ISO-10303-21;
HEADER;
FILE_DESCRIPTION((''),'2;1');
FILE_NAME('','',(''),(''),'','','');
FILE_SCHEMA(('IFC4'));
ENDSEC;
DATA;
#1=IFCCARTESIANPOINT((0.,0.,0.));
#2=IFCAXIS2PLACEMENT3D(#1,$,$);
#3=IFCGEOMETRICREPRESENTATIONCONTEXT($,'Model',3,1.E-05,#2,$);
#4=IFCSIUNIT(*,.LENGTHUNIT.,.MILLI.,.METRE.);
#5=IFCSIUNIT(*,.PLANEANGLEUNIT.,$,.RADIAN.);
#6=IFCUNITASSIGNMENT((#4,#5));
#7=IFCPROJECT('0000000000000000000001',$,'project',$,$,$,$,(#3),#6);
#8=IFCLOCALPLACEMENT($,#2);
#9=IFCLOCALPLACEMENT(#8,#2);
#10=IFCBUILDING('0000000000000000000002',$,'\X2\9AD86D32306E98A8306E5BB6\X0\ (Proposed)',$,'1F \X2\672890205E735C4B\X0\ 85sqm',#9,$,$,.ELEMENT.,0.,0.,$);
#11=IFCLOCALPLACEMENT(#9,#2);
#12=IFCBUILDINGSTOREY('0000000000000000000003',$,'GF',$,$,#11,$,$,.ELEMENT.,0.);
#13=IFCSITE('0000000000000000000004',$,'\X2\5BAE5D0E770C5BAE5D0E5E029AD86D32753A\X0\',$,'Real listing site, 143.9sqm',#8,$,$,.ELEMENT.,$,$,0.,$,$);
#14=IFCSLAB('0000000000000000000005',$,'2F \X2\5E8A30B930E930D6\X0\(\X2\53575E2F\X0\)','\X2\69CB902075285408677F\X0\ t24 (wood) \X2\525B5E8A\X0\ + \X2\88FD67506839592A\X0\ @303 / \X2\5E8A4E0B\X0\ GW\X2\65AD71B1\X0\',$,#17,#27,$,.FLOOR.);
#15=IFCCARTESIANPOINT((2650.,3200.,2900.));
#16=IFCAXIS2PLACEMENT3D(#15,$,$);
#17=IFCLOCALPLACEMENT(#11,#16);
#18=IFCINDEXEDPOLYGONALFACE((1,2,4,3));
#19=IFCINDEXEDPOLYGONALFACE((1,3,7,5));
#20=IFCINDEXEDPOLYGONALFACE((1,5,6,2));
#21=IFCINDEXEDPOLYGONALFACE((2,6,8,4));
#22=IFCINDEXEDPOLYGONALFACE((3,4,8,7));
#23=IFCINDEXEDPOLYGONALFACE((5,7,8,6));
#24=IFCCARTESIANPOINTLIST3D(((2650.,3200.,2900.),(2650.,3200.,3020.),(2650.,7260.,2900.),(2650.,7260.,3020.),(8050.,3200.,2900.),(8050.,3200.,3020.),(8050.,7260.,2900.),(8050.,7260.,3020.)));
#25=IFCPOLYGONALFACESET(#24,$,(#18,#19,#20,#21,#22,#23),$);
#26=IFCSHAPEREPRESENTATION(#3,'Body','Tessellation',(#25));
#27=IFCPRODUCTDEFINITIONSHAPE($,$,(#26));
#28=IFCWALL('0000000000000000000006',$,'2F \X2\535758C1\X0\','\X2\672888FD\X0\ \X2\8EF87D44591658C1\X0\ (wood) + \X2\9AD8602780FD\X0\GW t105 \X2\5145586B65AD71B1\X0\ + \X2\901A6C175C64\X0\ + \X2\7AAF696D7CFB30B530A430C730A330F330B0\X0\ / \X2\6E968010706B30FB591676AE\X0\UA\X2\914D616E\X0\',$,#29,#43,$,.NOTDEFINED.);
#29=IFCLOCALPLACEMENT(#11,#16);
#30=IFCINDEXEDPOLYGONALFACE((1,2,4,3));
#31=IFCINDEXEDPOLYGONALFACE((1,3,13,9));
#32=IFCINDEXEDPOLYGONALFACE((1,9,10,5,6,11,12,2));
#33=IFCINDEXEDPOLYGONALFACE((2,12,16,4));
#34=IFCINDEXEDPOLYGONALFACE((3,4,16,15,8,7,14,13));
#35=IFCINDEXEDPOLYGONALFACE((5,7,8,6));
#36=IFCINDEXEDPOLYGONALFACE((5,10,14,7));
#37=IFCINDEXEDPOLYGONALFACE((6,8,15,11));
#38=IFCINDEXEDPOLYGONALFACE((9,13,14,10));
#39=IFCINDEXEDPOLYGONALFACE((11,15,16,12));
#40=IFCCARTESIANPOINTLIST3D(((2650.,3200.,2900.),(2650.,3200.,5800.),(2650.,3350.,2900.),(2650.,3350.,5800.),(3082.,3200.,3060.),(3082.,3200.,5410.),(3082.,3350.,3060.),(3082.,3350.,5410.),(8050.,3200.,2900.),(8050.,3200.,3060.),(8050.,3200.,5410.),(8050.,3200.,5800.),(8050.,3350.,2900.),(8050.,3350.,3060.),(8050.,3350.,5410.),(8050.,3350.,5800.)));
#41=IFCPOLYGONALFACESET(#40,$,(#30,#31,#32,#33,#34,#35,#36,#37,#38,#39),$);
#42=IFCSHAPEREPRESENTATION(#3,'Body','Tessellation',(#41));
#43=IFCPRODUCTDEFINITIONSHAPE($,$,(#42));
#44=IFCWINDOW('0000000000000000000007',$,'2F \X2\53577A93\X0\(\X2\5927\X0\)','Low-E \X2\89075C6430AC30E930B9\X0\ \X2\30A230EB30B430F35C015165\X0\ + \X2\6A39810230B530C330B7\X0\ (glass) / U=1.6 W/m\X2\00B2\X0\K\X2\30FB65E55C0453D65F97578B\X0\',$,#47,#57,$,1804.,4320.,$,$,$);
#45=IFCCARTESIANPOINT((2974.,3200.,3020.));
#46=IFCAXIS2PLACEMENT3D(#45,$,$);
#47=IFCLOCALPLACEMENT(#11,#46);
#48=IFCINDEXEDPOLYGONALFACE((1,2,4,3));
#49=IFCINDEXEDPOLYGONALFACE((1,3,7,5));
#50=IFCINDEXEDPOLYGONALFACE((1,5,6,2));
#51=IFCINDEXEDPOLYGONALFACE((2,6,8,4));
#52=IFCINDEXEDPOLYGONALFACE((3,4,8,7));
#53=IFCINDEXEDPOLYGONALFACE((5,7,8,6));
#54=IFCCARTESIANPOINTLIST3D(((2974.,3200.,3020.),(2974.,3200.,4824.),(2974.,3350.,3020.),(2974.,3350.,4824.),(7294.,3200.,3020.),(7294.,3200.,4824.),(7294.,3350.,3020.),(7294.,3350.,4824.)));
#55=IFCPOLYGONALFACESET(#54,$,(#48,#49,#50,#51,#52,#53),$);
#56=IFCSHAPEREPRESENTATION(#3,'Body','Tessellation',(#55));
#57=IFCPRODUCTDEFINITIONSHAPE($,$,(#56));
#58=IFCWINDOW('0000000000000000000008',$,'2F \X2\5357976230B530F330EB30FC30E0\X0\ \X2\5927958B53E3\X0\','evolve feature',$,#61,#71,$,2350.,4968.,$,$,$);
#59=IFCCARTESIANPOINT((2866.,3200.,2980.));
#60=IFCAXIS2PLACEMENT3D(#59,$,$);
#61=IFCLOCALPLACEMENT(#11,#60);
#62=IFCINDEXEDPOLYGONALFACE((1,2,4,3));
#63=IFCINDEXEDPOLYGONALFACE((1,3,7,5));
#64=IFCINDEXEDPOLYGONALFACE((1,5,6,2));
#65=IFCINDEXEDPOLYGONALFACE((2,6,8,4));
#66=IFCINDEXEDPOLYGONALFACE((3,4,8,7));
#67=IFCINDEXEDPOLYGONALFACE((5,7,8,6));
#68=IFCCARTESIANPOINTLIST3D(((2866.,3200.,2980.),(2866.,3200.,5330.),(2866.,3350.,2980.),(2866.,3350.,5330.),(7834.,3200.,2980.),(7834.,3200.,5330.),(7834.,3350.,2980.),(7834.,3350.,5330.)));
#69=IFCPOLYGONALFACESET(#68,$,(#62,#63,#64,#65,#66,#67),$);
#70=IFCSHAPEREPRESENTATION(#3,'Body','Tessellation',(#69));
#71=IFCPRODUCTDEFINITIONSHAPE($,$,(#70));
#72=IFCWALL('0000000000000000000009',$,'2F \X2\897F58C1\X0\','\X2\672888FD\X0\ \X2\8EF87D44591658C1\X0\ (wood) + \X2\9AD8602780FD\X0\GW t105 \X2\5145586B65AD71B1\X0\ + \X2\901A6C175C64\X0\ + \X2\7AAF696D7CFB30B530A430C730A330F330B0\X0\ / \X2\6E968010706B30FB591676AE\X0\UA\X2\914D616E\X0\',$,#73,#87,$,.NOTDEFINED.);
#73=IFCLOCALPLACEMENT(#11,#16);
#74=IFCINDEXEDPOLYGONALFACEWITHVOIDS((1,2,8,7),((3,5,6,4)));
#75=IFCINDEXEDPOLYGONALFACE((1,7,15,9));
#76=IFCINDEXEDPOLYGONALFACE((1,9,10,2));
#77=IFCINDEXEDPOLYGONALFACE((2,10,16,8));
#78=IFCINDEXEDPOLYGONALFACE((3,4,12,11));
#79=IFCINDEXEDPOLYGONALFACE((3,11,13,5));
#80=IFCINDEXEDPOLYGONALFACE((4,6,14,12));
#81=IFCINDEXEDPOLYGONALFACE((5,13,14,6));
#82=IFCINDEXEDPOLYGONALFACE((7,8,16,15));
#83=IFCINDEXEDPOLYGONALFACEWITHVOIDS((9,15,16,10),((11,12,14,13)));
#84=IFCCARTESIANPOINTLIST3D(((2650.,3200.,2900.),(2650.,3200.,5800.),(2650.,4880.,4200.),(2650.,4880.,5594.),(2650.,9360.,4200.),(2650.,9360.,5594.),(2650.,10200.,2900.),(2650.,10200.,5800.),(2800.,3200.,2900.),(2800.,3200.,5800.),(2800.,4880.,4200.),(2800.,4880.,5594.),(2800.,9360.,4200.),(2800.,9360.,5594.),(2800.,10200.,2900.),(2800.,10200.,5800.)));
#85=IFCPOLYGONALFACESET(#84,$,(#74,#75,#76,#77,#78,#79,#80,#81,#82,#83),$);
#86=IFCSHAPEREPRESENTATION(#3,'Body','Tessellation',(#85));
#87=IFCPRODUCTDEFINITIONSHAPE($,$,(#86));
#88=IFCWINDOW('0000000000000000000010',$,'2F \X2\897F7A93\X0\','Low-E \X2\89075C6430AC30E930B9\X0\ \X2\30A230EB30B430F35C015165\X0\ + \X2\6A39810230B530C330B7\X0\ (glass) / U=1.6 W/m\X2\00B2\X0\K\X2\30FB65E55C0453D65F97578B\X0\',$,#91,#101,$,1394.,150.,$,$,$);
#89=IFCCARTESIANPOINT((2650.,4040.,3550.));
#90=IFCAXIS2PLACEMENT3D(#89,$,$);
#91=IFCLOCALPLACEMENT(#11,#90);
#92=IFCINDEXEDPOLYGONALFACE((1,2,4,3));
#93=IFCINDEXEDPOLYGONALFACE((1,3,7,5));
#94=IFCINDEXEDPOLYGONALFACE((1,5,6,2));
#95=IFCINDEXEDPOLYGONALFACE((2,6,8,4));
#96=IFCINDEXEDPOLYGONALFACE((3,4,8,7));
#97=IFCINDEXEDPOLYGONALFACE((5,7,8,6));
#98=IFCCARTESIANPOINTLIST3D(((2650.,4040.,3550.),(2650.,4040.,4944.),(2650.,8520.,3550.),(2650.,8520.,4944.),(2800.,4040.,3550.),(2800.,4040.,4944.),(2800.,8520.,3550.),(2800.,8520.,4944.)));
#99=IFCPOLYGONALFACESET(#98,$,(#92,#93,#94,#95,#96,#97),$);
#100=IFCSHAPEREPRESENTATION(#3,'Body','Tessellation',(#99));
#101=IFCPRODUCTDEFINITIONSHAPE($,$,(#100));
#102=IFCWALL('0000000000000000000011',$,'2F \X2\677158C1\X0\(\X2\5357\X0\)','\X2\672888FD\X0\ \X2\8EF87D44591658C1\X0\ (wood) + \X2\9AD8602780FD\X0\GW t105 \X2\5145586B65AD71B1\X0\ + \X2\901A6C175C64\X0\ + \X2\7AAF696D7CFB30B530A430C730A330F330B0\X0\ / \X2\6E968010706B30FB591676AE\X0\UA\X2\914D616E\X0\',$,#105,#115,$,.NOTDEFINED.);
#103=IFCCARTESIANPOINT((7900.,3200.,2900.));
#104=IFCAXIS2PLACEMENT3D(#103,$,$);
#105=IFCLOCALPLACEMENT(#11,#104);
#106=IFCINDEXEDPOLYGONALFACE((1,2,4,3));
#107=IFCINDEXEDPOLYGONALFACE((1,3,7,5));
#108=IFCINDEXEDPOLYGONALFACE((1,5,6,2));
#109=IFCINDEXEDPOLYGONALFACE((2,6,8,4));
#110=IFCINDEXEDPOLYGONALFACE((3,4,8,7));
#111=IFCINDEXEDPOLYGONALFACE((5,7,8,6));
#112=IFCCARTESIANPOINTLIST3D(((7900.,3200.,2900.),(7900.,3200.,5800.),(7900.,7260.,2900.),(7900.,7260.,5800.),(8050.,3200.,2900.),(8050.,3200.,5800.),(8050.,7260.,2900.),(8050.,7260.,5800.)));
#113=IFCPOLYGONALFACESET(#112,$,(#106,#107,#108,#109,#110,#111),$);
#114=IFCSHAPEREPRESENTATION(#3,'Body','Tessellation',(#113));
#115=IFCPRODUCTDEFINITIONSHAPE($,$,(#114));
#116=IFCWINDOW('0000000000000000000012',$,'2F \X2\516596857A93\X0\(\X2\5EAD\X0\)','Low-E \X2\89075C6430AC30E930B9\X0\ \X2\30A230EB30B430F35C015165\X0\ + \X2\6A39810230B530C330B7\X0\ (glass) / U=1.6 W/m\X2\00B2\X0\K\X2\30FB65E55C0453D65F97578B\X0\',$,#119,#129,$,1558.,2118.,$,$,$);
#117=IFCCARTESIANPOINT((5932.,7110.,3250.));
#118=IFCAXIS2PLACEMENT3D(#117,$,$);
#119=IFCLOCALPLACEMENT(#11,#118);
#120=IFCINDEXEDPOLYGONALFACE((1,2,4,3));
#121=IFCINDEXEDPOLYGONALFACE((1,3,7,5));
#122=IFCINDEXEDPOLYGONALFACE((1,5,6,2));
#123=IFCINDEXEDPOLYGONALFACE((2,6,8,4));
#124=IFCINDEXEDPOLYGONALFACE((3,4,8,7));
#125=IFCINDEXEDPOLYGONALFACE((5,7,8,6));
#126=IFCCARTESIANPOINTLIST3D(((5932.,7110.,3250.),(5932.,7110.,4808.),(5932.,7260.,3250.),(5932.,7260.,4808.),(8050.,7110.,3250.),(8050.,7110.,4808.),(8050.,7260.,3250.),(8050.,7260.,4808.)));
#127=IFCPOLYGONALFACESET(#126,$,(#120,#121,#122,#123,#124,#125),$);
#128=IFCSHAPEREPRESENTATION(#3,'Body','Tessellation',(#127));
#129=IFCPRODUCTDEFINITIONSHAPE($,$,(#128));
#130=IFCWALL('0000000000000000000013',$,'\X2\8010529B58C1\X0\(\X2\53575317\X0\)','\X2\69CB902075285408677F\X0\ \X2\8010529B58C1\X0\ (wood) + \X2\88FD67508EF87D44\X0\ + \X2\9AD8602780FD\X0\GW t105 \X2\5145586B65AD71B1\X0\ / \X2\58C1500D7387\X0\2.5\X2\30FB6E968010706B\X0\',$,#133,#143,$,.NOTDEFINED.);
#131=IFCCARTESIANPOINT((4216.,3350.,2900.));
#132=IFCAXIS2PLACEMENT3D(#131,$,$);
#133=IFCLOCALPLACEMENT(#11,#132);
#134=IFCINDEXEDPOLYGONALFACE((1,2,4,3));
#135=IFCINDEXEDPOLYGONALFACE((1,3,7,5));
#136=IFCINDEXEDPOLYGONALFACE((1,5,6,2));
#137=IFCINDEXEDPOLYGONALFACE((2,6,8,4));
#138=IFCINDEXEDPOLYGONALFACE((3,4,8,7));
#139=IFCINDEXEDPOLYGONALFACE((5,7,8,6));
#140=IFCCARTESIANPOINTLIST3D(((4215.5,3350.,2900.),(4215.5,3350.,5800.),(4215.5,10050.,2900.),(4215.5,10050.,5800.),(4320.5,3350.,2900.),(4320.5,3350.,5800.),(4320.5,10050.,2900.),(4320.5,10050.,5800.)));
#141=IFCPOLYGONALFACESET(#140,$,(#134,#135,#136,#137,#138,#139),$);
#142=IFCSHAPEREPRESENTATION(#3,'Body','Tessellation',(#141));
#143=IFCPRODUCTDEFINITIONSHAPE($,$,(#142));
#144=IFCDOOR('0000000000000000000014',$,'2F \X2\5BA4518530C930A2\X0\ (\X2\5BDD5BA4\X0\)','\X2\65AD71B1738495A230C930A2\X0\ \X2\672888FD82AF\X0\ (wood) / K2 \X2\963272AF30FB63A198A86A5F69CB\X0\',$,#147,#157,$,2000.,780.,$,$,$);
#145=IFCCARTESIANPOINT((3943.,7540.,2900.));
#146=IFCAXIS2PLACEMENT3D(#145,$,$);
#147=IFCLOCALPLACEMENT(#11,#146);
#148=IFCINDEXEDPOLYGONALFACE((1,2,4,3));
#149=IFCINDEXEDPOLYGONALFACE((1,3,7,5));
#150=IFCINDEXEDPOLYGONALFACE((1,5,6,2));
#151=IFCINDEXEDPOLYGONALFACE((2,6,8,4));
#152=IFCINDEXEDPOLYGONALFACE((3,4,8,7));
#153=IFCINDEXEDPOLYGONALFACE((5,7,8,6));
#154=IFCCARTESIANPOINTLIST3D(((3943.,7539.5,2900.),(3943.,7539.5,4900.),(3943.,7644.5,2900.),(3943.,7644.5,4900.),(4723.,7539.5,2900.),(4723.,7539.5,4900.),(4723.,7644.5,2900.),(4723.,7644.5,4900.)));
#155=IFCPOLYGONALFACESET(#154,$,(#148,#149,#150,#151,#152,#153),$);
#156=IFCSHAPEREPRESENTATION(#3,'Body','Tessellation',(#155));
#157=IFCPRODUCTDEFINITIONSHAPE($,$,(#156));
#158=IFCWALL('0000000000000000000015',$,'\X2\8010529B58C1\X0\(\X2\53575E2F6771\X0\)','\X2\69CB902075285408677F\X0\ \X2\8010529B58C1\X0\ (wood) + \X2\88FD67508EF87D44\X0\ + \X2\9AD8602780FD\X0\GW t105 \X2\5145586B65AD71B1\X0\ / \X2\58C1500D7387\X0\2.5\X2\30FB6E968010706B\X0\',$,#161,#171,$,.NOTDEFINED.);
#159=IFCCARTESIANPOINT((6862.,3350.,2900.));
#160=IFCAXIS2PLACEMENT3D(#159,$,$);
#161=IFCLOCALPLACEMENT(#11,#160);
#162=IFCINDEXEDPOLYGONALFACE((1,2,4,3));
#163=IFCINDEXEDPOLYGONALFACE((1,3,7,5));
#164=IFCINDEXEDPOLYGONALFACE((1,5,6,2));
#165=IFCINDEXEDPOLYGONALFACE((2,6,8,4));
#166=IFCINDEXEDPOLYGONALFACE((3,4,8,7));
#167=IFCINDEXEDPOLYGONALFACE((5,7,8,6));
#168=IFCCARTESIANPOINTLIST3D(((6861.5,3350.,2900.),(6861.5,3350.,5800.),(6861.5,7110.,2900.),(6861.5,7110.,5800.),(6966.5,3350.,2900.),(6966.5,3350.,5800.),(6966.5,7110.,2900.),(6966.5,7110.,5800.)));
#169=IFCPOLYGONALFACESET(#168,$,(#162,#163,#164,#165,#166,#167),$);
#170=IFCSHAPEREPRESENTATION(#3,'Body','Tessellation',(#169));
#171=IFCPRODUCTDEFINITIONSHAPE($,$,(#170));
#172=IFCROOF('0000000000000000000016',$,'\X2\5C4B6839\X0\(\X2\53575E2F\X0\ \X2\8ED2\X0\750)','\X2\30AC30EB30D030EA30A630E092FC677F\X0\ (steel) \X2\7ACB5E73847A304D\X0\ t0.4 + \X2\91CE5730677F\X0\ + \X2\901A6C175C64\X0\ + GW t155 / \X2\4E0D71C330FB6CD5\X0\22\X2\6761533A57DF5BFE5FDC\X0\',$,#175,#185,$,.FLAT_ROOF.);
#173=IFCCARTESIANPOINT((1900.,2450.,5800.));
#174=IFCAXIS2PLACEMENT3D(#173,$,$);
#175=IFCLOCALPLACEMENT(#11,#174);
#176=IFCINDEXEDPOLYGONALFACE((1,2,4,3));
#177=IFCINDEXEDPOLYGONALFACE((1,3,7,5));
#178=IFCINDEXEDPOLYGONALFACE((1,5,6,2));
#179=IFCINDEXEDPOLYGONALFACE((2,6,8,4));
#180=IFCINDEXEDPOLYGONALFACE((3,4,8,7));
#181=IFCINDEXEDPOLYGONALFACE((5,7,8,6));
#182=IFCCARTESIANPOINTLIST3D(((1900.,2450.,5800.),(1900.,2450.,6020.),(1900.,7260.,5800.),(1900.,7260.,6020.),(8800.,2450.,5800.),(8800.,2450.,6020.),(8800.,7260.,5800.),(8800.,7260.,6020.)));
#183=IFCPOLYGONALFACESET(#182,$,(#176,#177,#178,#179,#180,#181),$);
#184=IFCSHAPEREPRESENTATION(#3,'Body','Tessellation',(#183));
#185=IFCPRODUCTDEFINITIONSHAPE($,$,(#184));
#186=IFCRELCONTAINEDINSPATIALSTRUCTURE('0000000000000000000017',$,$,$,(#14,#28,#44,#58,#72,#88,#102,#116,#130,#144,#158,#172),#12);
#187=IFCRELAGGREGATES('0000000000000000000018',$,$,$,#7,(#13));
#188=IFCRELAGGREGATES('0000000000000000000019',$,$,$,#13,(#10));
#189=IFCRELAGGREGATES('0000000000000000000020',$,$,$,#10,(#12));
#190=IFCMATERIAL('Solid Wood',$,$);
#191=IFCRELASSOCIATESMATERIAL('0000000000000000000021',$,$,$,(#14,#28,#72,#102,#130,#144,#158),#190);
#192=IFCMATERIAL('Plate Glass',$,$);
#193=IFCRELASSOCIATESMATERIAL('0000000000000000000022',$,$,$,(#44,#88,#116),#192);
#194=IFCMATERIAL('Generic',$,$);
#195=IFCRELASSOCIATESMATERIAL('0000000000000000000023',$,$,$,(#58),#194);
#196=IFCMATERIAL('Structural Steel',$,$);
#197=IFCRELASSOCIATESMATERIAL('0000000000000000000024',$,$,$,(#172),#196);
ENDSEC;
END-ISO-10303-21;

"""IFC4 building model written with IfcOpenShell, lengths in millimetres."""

from ifc_helpers import new_model, si_unit, frame, frame_2d, origin, place, context, project, spatial, rectangle, extrude, material, element, fill, save


model = new_model("IFC4")

# Units and contexts
model_context = context("Model", 3, precision=1e-05, world=origin())
ifc_project = project(units=[si_unit("LENGTHUNIT", "METRE", prefix="MILLI"), si_unit("PLANEANGLEUNIT", "RADIAN")], contexts=[model_context])

# Site, building, storey
site_placement = place(None, origin())
site = spatial("IfcSite", under=ifc_project, at=site_placement, Name="宮崎県宮崎市高洲町", ObjectType="Real listing site, 143.9sqm", CompositionType="ELEMENT", RefElevation=0.0)
building_placement = place(site_placement, origin())
building = spatial("IfcBuilding", under=site, at=building_placement, Name="高洲の風の家 (Proposed)", ObjectType="1F 木造平屋 85sqm", CompositionType="ELEMENT", ElevationOfRefHeight=0.0, ElevationOfTerrain=0.0)
storey_placement = place(building_placement, origin())
storey = spatial("IfcBuildingStorey", under=building, at=storey_placement, Name="GF", CompositionType="ELEMENT", Elevation=0.0)

# Slab
ifc_material_1 = material(Name="Solid Wood")
slab_placement = place(storey_placement, frame((2650.0, 3200.0, 2900.0)))
element("IfcSlab", 1, at=slab_placement, inside=storey, material=ifc_material_1, Name="2F 床スラブ(南帯)", Description="構造用合板 t24 (wood) 剛床 + 製材根太 @303 / 床下 GW断熱", PredefinedType="FLOOR", context=model_context, shape_type="SweptSolid", body=[
    extrude(rectangle(XDim=5400.0, YDim=4060.0, at=frame_2d((2700.0, 2030.0))), frame((2650.0, 3200.0, 2900.0)), (0.0, 0.0, 1.0), 120.0),
])

# Wall, openings, windows
wall_1_placement = place(storey_placement, frame((2650.0, 3200.0, 2900.0)))
wall_1 = element("IfcWall", 2, at=wall_1_placement, inside=storey, material=ifc_material_1, Name="2F 南壁", Description="木製 軸組外壁 (wood) + 高性能GW t105 充填断熱 + 通気層 + 窯業系サイディング / 準耐火・外皮UA配慮", PredefinedType="NOTDEFINED", context=model_context, shape_type="SweptSolid", body=[
    extrude(rectangle(XDim=5400.0, YDim=150.0, at=frame_2d((2700.0, 75.0))), frame((2650.0, 3200.0, 2900.0)), (0.0, 0.0, 1.0), 2900.0),
])
opening_1_placement = place(storey_placement, frame((2974.0, 3200.0, 3020.0)))
opening_1 = element("IfcOpeningElement", 3, at=opening_1_placement, cuts=wall_1, PredefinedType="NOTDEFINED", context=model_context, shape_type="SweptSolid", body=[
    extrude(rectangle(XDim=4320.0, YDim=150.0, at=frame_2d((2160.0, 75.0))), frame((2974.0, 3200.0, 3020.0)), (0.0, 0.0, 1.0), 1804.0),
])
opening_2_placement = place(storey_placement, frame((2866.0, 3200.0, 2980.0)))
opening_2 = element("IfcOpeningElement", 4, at=opening_2_placement, cuts=wall_1, PredefinedType="NOTDEFINED", context=model_context, shape_type="SweptSolid", body=[
    extrude(rectangle(XDim=4968.0, YDim=150.0, at=frame_2d((2484.0, 75.0))), frame((2866.0, 3200.0, 2980.0)), (0.0, 0.0, 1.0), 2350.0),
])
ifc_material_2 = material(Name="Plate Glass")
window_1_placement = place(storey_placement, frame((2974.0, 3200.0, 3020.0)))
window_1 = element("IfcWindow", 5, at=window_1_placement, inside=storey, material=ifc_material_2, Name="2F 南窓(大)", Description="Low-E 複層ガラス アルゴン封入 + 樹脂サッシ (glass) / U=1.6 W/m²K・日射取得型", OverallHeight=1804.0, OverallWidth=4320.0, context=model_context, shape_type="SweptSolid", body=[
    extrude(rectangle(XDim=4320.0, YDim=150.0, at=frame_2d((2160.0, 75.0))), frame((2974.0, 3200.0, 3020.0)), (0.0, 0.0, 1.0), 1804.0),
])
fill(opening_1, window_1)
ifc_material_3 = material(Name="Generic")
window_2_placement = place(storey_placement, frame((2866.0, 3200.0, 2980.0)))
window_2 = element("IfcWindow", 6, at=window_2_placement, inside=storey, material=ifc_material_3, Name="2F 南面サンルーム 大開口", Description="evolve feature", OverallHeight=2350.0, OverallWidth=4968.0, context=model_context, shape_type="SweptSolid", body=[
    extrude(rectangle(XDim=4968.0, YDim=150.0, at=frame_2d((2484.0, 75.0))), frame((2866.0, 3200.0, 2980.0)), (0.0, 0.0, 1.0), 2350.0),
])
fill(opening_2, window_2)

# Walls, openings, windows
wall_2_placement = place(storey_placement, frame((2650.0, 3200.0, 2900.0)))
wall_2 = element("IfcWall", 7, at=wall_2_placement, inside=storey, material=ifc_material_1, Name="2F 西壁", Description="木製 軸組外壁 (wood) + 高性能GW t105 充填断熱 + 通気層 + 窯業系サイディング / 準耐火・外皮UA配慮", PredefinedType="NOTDEFINED", context=model_context, shape_type="SweptSolid", body=[
    extrude(rectangle(XDim=150.0, YDim=7000.0, at=frame_2d((75.0, 3500.0))), frame((2650.0, 3200.0, 2900.0)), (0.0, 0.0, 1.0), 2900.0),
])
opening_3_placement = place(storey_placement, frame((2650.0, 4040.0, 3550.0)))
opening_3 = element("IfcOpeningElement", 8, at=opening_3_placement, cuts=wall_2, PredefinedType="NOTDEFINED", context=model_context, shape_type="SweptSolid", body=[
    extrude(rectangle(XDim=150.0, YDim=4480.0, at=frame_2d((75.0, 2240.0))), frame((2650.0, 4040.0, 3550.0)), (0.0, 0.0, 1.0), 1394.0),
])
window_3_placement = place(storey_placement, frame((2650.0, 4040.0, 3550.0)))
window_3 = element("IfcWindow", 9, at=window_3_placement, inside=storey, material=ifc_material_2, Name="2F 西窓", Description="Low-E 複層ガラス アルゴン封入 + 樹脂サッシ (glass) / U=1.6 W/m²K・日射取得型", OverallHeight=1394.0, OverallWidth=150.0, context=model_context, shape_type="SweptSolid", body=[
    extrude(rectangle(XDim=150.0, YDim=4480.0, at=frame_2d((75.0, 2240.0))), frame((2650.0, 4040.0, 3550.0)), (0.0, 0.0, 1.0), 1394.0),
])
fill(opening_3, window_3)
wall_3_placement = place(storey_placement, frame((7900.0, 3200.0, 2900.0)))
wall_3 = element("IfcWall", 10, at=wall_3_placement, inside=storey, material=ifc_material_1, Name="2F 東壁(南)", Description="木製 軸組外壁 (wood) + 高性能GW t105 充填断熱 + 通気層 + 窯業系サイディング / 準耐火・外皮UA配慮", PredefinedType="NOTDEFINED", context=model_context, shape_type="SweptSolid", body=[
    extrude(rectangle(XDim=150.0, YDim=4060.0, at=frame_2d((75.0, 2030.0))), frame((7900.0, 3200.0, 2900.0)), (0.0, 0.0, 1.0), 2900.0),
])
opening_4_placement = place(storey_placement, frame((5932.0, 7110.0, 3250.0)))
opening_4 = element("IfcOpeningElement", 11, at=opening_4_placement, cuts=wall_3, PredefinedType="NOTDEFINED", context=model_context, shape_type="SweptSolid", body=[
    extrude(rectangle(XDim=2118.0, YDim=150.0, at=frame_2d((1059.0, 75.0))), frame((5932.0, 7110.0, 3250.0)), (0.0, 0.0, 1.0), 1558.0),
])
window_4_placement = place(storey_placement, frame((5932.0, 7110.0, 3250.0)))
window_4 = element("IfcWindow", 12, at=window_4_placement, inside=storey, material=ifc_material_2, Name="2F 入隅窓(庭)", Description="Low-E 複層ガラス アルゴン封入 + 樹脂サッシ (glass) / U=1.6 W/m²K・日射取得型", OverallHeight=1558.0, OverallWidth=2118.0, context=model_context, shape_type="SweptSolid", body=[
    extrude(rectangle(XDim=2118.0, YDim=150.0, at=frame_2d((1059.0, 75.0))), frame((5932.0, 7110.0, 3250.0)), (0.0, 0.0, 1.0), 1558.0),
])
fill(opening_4, window_4)

# Wall, opening, door
wall_4_placement = place(storey_placement, frame((4216.0, 3350.0, 2900.0)))
wall_4 = element("IfcWall", 13, at=wall_4_placement, inside=storey, material=ifc_material_1, Name="耐力壁(南北)", Description="構造用合板 耐力壁 (wood) + 製材軸組 + 高性能GW t105 充填断熱 / 壁倍率2.5・準耐火", PredefinedType="NOTDEFINED", context=model_context, shape_type="SweptSolid", body=[
    extrude(rectangle(XDim=105.0, YDim=6700.0, at=frame_2d((52.0, 3350.0))), frame((4216.0, 3350.0, 2900.0)), (0.0, 0.0, 1.0), 2900.0),
])
opening_5_placement = place(storey_placement, frame((3943.0, 7540.0, 2900.0)))
opening_5 = element("IfcOpeningElement", 14, at=opening_5_placement, cuts=wall_4, PredefinedType="NOTDEFINED", context=model_context, shape_type="SweptSolid", body=[
    extrude(rectangle(XDim=780.0, YDim=105.0, at=frame_2d((390.0, 52.0))), frame((3943.0, 7540.0, 2900.0)), (0.0, 0.0, 1.0), 2000.0),
])
door_placement = place(storey_placement, frame((3943.0, 7540.0, 2900.0)))
door = element("IfcDoor", 15, at=door_placement, inside=storey, material=ifc_material_1, Name="2F 室内ドア (寝室)", Description="断熱玄関ドア 木製芯 (wood) / K2 防犯・採風機構", OverallHeight=2000.0, OverallWidth=780.0, context=model_context, shape_type="SweptSolid", body=[
    extrude(rectangle(XDim=780.0, YDim=105.0, at=frame_2d((390.0, 52.0))), frame((3943.0, 7540.0, 2900.0)), (0.0, 0.0, 1.0), 2000.0),
])
fill(opening_5, door)

# Wall
wall_5_placement = place(storey_placement, frame((6862.0, 3350.0, 2900.0)))
element("IfcWall", 16, at=wall_5_placement, inside=storey, material=ifc_material_1, Name="耐力壁(南帯東)", Description="構造用合板 耐力壁 (wood) + 製材軸組 + 高性能GW t105 充填断熱 / 壁倍率2.5・準耐火", PredefinedType="NOTDEFINED", context=model_context, shape_type="SweptSolid", body=[
    extrude(rectangle(XDim=105.0, YDim=3760.0, at=frame_2d((52.0, 1880.0))), frame((6862.0, 3350.0, 2900.0)), (0.0, 0.0, 1.0), 2900.0),
])

# Roof
ifc_material_4 = material(Name="Structural Steel")
for number, where, name in (
    (17, (1900.0, 2450.0, 5800.0), "屋根(南帯 軒750)"),
):
    element("IfcRoof", number, at=place(storey_placement, frame(where)), inside=storey, material=ifc_material_4, Name=name, Description="ガルバリウム鋼板 (steel) 立平葺き t0.4 + 野地板 + 通気層 + GW t155 / 不燃・法22条区域対応", PredefinedType="FLAT_ROOF", context=model_context, shape_type="SweptSolid", body=[
        extrude(rectangle(XDim=6900.0, YDim=4810.0, at=frame_2d((3450.0, 2405.0))), frame((1900.0, 2450.0, 5800.0)), (0.0, 0.0, 1.0), 220.0),
    ])

save(model, "model.ifc")
